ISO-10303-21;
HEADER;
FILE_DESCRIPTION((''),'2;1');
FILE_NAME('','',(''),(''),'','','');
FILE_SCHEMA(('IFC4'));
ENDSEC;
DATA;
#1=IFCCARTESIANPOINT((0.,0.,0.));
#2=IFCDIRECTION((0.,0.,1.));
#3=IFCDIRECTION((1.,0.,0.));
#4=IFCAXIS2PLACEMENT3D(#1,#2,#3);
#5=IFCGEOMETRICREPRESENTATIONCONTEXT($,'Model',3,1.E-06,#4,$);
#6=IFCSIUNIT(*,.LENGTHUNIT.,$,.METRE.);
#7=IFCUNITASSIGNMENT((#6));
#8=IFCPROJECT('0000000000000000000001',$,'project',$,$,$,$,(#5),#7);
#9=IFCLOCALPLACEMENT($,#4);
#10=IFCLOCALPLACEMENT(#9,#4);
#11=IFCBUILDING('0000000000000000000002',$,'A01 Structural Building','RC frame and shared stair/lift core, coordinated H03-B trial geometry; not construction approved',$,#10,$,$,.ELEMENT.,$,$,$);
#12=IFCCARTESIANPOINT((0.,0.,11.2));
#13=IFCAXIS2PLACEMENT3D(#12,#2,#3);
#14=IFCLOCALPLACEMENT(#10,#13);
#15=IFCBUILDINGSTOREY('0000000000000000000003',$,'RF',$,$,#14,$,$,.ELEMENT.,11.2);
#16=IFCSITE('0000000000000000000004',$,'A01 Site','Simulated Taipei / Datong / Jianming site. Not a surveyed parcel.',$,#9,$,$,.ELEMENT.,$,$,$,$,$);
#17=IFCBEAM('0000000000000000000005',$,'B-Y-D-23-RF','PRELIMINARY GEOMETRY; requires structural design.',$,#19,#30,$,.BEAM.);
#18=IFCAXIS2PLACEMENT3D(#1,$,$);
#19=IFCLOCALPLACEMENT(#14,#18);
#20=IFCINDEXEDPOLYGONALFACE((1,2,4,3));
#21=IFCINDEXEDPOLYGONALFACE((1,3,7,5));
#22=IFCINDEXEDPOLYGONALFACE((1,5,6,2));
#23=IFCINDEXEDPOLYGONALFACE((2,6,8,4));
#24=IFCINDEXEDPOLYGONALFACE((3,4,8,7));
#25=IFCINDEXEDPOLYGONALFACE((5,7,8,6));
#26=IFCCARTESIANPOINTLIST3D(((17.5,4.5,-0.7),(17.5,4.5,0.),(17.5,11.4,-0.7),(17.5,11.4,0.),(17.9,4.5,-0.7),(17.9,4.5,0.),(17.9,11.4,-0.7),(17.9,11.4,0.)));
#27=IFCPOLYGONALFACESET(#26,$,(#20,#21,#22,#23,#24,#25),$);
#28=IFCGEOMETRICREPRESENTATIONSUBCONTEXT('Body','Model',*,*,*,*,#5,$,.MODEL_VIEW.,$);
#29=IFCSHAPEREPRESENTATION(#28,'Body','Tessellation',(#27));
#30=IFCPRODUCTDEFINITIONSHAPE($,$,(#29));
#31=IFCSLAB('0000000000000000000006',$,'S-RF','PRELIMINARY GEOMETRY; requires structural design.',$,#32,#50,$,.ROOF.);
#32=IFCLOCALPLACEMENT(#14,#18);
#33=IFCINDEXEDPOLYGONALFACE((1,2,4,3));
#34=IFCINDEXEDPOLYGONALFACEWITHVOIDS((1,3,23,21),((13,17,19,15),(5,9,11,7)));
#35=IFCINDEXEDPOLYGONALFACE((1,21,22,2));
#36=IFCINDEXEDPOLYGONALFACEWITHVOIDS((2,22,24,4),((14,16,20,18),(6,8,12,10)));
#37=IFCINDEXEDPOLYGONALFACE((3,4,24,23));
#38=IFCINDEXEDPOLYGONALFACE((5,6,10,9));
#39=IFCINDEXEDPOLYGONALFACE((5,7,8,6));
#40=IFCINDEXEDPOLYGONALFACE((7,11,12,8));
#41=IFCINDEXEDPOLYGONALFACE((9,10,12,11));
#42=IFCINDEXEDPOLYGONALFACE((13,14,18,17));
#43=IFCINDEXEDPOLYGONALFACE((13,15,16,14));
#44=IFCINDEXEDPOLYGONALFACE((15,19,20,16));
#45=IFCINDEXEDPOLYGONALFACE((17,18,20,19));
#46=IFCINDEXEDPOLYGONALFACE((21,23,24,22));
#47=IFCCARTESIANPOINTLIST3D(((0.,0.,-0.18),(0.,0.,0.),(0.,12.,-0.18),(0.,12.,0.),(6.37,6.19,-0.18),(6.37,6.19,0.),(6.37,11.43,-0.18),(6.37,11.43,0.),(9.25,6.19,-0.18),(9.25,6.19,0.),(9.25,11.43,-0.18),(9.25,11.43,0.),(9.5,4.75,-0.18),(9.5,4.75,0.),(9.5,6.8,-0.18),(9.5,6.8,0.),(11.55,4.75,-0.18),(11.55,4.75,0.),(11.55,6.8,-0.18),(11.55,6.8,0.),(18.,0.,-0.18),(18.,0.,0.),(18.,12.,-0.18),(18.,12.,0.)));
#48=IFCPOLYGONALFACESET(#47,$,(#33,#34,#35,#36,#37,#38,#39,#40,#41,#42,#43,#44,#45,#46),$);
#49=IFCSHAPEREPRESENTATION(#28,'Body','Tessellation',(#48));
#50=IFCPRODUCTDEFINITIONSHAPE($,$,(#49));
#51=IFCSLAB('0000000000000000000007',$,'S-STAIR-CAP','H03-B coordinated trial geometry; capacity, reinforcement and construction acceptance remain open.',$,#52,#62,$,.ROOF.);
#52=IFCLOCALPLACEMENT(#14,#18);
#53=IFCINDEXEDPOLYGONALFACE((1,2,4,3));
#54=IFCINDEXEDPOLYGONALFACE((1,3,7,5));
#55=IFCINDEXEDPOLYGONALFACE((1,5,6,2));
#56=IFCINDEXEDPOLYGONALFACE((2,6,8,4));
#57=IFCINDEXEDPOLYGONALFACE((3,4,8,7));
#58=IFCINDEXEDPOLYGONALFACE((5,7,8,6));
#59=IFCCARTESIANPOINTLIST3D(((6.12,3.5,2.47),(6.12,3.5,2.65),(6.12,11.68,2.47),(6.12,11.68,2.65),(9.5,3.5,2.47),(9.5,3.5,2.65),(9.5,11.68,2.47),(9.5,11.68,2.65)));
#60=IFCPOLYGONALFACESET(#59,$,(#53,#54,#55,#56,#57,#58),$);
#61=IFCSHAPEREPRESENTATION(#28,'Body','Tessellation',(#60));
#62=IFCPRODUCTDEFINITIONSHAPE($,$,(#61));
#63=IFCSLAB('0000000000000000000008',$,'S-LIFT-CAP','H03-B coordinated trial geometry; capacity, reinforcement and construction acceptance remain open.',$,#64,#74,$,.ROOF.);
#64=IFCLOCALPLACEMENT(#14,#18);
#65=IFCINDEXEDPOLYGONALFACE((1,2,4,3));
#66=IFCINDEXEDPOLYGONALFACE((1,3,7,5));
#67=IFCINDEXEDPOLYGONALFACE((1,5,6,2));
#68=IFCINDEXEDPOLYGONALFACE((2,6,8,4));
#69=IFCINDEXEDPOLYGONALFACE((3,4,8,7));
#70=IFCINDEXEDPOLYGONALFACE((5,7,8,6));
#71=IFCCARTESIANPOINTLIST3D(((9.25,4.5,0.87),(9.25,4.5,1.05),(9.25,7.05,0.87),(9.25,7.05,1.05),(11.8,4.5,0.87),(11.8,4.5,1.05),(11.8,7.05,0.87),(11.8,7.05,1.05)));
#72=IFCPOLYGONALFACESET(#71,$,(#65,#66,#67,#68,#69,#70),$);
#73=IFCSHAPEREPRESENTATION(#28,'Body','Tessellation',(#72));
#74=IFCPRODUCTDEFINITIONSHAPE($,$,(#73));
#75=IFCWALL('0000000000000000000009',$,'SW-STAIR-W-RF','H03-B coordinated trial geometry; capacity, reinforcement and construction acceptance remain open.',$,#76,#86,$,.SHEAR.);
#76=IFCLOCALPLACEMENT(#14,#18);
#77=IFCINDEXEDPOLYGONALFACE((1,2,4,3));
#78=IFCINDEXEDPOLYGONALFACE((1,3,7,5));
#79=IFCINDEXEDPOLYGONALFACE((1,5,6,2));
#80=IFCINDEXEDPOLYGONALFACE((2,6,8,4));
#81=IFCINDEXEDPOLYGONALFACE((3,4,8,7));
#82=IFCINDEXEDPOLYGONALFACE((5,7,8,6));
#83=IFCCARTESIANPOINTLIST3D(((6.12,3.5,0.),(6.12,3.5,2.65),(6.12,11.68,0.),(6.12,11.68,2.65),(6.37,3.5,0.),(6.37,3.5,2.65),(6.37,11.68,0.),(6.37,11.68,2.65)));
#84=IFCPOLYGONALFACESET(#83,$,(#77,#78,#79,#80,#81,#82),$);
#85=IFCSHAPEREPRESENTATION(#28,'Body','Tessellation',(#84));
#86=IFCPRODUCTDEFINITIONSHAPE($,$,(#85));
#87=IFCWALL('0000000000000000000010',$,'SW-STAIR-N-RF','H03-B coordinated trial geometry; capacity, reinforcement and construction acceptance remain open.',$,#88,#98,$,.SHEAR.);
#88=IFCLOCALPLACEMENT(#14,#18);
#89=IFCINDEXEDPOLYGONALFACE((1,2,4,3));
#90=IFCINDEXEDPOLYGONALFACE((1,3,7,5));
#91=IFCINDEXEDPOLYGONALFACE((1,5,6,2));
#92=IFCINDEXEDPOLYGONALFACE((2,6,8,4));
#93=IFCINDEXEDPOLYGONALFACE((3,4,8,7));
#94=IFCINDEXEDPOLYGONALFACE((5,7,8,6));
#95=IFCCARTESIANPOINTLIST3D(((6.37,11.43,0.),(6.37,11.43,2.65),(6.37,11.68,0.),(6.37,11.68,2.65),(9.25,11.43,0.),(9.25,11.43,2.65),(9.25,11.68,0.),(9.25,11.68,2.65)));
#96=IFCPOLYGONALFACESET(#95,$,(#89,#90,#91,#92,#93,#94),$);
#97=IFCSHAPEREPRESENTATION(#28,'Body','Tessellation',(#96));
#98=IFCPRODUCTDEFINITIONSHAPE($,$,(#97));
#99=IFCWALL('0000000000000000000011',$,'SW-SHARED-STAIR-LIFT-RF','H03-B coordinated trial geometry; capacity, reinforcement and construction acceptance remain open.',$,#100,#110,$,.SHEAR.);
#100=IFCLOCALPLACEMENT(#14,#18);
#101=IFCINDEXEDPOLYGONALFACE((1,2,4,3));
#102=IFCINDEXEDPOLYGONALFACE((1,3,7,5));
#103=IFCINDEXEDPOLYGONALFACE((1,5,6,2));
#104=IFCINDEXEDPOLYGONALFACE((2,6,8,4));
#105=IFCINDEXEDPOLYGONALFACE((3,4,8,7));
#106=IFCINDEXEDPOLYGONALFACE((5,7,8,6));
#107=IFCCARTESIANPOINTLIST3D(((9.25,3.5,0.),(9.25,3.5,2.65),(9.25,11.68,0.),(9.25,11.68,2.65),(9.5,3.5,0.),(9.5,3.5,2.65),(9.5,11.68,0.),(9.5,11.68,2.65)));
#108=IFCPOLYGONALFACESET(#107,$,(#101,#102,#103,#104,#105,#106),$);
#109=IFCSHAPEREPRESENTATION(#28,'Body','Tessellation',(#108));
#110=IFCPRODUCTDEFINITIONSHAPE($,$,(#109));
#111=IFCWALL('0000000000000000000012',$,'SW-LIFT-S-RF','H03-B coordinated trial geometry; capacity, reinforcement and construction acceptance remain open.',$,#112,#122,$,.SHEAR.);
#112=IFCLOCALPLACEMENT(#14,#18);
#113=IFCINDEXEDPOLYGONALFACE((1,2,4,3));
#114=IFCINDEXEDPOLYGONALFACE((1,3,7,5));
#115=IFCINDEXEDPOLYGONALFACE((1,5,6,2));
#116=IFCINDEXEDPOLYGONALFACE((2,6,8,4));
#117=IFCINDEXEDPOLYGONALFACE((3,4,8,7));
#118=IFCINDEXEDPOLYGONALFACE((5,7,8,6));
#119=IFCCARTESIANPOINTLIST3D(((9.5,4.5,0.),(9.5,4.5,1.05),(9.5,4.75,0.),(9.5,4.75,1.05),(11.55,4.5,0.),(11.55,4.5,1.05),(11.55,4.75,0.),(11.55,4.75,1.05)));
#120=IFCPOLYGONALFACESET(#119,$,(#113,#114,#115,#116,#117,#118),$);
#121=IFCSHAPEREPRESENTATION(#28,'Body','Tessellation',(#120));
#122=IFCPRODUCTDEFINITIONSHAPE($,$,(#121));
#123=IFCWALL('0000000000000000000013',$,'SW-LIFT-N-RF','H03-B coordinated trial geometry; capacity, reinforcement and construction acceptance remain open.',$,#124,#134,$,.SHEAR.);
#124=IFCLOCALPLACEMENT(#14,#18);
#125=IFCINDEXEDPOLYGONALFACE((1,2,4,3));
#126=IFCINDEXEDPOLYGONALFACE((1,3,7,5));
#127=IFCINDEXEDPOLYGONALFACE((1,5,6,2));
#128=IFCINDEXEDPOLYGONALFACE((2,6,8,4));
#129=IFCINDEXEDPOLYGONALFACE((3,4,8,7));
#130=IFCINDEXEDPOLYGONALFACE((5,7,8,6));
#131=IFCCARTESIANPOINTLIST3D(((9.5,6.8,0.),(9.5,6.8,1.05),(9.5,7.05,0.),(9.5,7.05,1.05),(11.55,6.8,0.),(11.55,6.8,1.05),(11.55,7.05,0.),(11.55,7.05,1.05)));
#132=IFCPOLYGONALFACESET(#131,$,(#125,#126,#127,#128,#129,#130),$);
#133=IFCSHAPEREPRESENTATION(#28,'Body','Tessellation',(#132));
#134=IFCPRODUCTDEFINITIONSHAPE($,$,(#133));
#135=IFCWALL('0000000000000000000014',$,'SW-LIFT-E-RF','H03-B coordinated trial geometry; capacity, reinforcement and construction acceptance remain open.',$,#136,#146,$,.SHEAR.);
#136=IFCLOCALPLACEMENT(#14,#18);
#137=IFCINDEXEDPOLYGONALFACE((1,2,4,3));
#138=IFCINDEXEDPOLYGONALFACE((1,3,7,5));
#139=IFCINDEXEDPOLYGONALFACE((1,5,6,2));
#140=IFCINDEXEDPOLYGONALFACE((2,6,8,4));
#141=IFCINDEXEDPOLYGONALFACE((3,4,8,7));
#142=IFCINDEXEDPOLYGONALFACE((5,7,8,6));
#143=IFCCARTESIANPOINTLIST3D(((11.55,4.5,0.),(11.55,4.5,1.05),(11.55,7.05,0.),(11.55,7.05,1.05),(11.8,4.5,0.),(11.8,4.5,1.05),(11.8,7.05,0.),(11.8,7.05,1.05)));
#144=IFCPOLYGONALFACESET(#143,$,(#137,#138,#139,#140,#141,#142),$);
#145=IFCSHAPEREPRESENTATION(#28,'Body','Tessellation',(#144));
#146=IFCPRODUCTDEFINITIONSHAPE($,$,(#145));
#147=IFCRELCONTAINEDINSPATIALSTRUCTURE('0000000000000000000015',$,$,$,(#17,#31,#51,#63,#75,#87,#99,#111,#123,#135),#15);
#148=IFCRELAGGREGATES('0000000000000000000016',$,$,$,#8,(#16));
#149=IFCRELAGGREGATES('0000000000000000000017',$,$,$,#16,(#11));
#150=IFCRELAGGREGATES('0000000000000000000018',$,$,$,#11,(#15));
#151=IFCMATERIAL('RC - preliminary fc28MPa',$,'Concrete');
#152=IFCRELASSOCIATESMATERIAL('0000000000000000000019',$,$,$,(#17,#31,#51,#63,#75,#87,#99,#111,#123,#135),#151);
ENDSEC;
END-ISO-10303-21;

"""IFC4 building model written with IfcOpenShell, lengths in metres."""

from ifc_helpers import new_model, si_unit, frame, origin_with_axes, place, context, subcontext, project, spatial, polyline, rectangle, outline, extrude, material, element, save


model = new_model("IFC4")

# Units and contexts
model_context = context("Model", 3, precision=1e-06, world=origin_with_axes())
body_context = subcontext(model_context, "Body", "Model", "MODEL_VIEW")
ifc_project = project(units=[si_unit("LENGTHUNIT", "METRE")], contexts=[model_context])

# Site, building, storey
site_placement = place(None, origin_with_axes())
site = spatial("IfcSite", under=ifc_project, at=site_placement, Name="A01 Site", Description="Simulated Taipei / Datong / Jianming site. Not a surveyed parcel.", CompositionType="ELEMENT")
building_placement = place(site_placement, origin_with_axes())
building = spatial("IfcBuilding", under=site, at=building_placement, Name="A01 Structural Building", Description="RC frame and shared stair/lift core, coordinated H03-B trial geometry; not construction approved", CompositionType="ELEMENT")
storey_placement = place(building_placement, frame((0.0, 0.0, 11.2), z_axis=(0.0, 0.0, 1.0), x_axis=(1.0, 0.0, 0.0)))
storey = spatial("IfcBuildingStorey", under=building, at=storey_placement, Name="RF", CompositionType="ELEMENT", Elevation=11.2)

# Beam
ifc_material = material(Name="RC - preliminary fc28MPa", Category="Concrete")
beam_1_placement = place(storey_placement, frame((17.7, 7.95, -0.7), z_axis=(0.0, 0.0, 1.0), x_axis=(1.0, 0.0, 0.0)))
element("IfcBeam", 1, at=beam_1_placement, inside=storey, material=ifc_material, Name="B-Y-D-23-RF", Description="PRELIMINARY GEOMETRY; requires structural design.", PredefinedType="BEAM", context=body_context, shape_type="SweptSolid", body=[
    extrude(rectangle(XDim=0.4, YDim=6.9), origin_with_axes(), (0.0, 0.0, 1.0), 0.7),
])

# Slab, openings
slab_1_placement = place(storey_placement, frame((9.0, 6.0, -0.18), z_axis=(0.0, 0.0, 1.0), x_axis=(1.0, 0.0, 0.0)))
slab_1 = element("IfcSlab", 2, at=slab_1_placement, inside=storey, material=ifc_material, Name="S-RF", Description="PRELIMINARY GEOMETRY; requires structural design.", PredefinedType="ROOF", context=body_context, shape_type="SweptSolid", body=[
    extrude(rectangle(XDim=18.0, YDim=12.0), origin_with_axes(), (0.0, 0.0, 1.0), 0.18),
])
opening_1_placement = place(storey_placement, frame((10.525, 5.775, -0.23), z_axis=(0.0, 0.0, 1.0), x_axis=(1.0, 0.0, 0.0)))
element("IfcOpeningElement", 3, at=opening_1_placement, cuts=slab_1, PredefinedType="OPENING", context=body_context, shape_type="SweptSolid", body=[
    extrude(rectangle(XDim=2.05, YDim=2.05), origin_with_axes(), (0.0, 0.0, 1.0), 0.28),
])
placement = place(None, origin_with_axes())
element("IfcOpeningElement", 4, at=placement, cuts=slab_1, PredefinedType="OPENING", context=body_context, shape_type="SweptSolid", body=[
    extrude(outline(polyline([(6.37, 6.19), (6.37, 11.43), (9.25, 11.43), (9.25, 6.19), (7.7, 6.19), (7.7, 6.19), (6.37, 6.19)])), frame((0.0, 0.0, 10.97), z_axis=(0.0, 0.0, 1.0), x_axis=(1.0, 0.0, 0.0)), (0.0, 0.0, 1.0), 0.28),
])

# Slabs
element("IfcSlab", 5, at=placement, inside=storey, material=ifc_material, Name="S-STAIR-CAP", Description="H03-B coordinated trial geometry; capacity, reinforcement and construction acceptance remain open.", PredefinedType="ROOF", context=body_context, shape_type="SweptSolid", body=[
    extrude(outline(polyline([(9.5, 3.5), (9.5, 11.68), (6.12, 11.68), (6.12, 3.5), (9.5, 3.5)])), frame((0.0, 0.0, 13.67), z_axis=(0.0, 0.0, 1.0), x_axis=(1.0, 0.0, 0.0)), (0.0, 0.0, 1.0), 0.18),
])
element("IfcSlab", 6, at=placement, inside=storey, material=ifc_material, Name="S-LIFT-CAP", Description="H03-B coordinated trial geometry; capacity, reinforcement and construction acceptance remain open.", PredefinedType="ROOF", context=body_context, shape_type="SweptSolid", body=[
    extrude(outline(polyline([(11.8, 4.5), (11.8, 7.05), (9.25, 7.05), (9.25, 4.5), (11.8, 4.5)])), frame((0.0, 0.0, 12.07), z_axis=(0.0, 0.0, 1.0), x_axis=(1.0, 0.0, 0.0)), (0.0, 0.0, 1.0), 0.18),
])

# Wall
element("IfcWall", 7, at=placement, inside=storey, material=ifc_material, Name="SW-STAIR-W-RF", Description="H03-B coordinated trial geometry; capacity, reinforcement and construction acceptance remain open.", PredefinedType="SHEAR", context=body_context, shape_type="SweptSolid", body=[
    extrude(outline(polyline([(6.37, 3.5), (6.37, 11.68), (6.12, 11.68), (6.12, 3.5), (6.37, 3.5)])), frame((0.0, 0.0, 11.2), z_axis=(0.0, 0.0, 1.0), x_axis=(1.0, 0.0, 0.0)), (0.0, 0.0, 1.0), 2.65),
])

# Walls
element("IfcWall", 8, at=placement, inside=storey, material=ifc_material, Name="SW-STAIR-N-RF", Description="H03-B coordinated trial geometry; capacity, reinforcement and construction acceptance remain open.", PredefinedType="SHEAR", context=body_context, shape_type="SweptSolid", body=[
    extrude(outline(polyline([(9.25, 11.43), (9.25, 11.68), (6.37, 11.68), (6.37, 11.43), (9.25, 11.43)])), frame((0.0, 0.0, 11.2), z_axis=(0.0, 0.0, 1.0), x_axis=(1.0, 0.0, 0.0)), (0.0, 0.0, 1.0), 2.65),
])
element("IfcWall", 9, at=placement, inside=storey, material=ifc_material, Name="SW-SHARED-STAIR-LIFT-RF", Description="H03-B coordinated trial geometry; capacity, reinforcement and construction acceptance remain open.", PredefinedType="SHEAR", context=body_context, shape_type="SweptSolid", body=[
    extrude(outline(polyline([(9.5, 3.5), (9.5, 11.68), (9.25, 11.68), (9.25, 3.5), (9.5, 3.5)])), frame((0.0, 0.0, 11.2), z_axis=(0.0, 0.0, 1.0), x_axis=(1.0, 0.0, 0.0)), (0.0, 0.0, 1.0), 2.65),
])
element("IfcWall", 10, at=placement, inside=storey, material=ifc_material, Name="SW-LIFT-S-RF", Description="H03-B coordinated trial geometry; capacity, reinforcement and construction acceptance remain open.", PredefinedType="SHEAR", context=body_context, shape_type="SweptSolid", body=[
    extrude(outline(polyline([(11.55, 4.5), (11.55, 4.75), (9.5, 4.75), (9.5, 4.5), (11.55, 4.5)])), frame((0.0, 0.0, 11.2), z_axis=(0.0, 0.0, 1.0), x_axis=(1.0, 0.0, 0.0)), (0.0, 0.0, 1.0), 1.05),
])
element("IfcWall", 11, at=placement, inside=storey, material=ifc_material, Name="SW-LIFT-N-RF", Description="H03-B coordinated trial geometry; capacity, reinforcement and construction acceptance remain open.", PredefinedType="SHEAR", context=body_context, shape_type="SweptSolid", body=[
    extrude(outline(polyline([(11.55, 6.8), (11.55, 7.05), (9.5, 7.05), (9.5, 6.8), (11.55, 6.8)])), frame((0.0, 0.0, 11.2), z_axis=(0.0, 0.0, 1.0), x_axis=(1.0, 0.0, 0.0)), (0.0, 0.0, 1.0), 1.05),
])
element("IfcWall", 12, at=placement, inside=storey, material=ifc_material, Name="SW-LIFT-E-RF", Description="H03-B coordinated trial geometry; capacity, reinforcement and construction acceptance remain open.", PredefinedType="SHEAR", context=body_context, shape_type="SweptSolid", body=[
    extrude(outline(polyline([(11.8, 4.5), (11.8, 7.05), (11.55, 7.05), (11.55, 4.5), (11.8, 4.5)])), frame((0.0, 0.0, 11.2), z_axis=(0.0, 0.0, 1.0), x_axis=(1.0, 0.0, 0.0)), (0.0, 0.0, 1.0), 1.05),
])

save(model, "model.ifc")
